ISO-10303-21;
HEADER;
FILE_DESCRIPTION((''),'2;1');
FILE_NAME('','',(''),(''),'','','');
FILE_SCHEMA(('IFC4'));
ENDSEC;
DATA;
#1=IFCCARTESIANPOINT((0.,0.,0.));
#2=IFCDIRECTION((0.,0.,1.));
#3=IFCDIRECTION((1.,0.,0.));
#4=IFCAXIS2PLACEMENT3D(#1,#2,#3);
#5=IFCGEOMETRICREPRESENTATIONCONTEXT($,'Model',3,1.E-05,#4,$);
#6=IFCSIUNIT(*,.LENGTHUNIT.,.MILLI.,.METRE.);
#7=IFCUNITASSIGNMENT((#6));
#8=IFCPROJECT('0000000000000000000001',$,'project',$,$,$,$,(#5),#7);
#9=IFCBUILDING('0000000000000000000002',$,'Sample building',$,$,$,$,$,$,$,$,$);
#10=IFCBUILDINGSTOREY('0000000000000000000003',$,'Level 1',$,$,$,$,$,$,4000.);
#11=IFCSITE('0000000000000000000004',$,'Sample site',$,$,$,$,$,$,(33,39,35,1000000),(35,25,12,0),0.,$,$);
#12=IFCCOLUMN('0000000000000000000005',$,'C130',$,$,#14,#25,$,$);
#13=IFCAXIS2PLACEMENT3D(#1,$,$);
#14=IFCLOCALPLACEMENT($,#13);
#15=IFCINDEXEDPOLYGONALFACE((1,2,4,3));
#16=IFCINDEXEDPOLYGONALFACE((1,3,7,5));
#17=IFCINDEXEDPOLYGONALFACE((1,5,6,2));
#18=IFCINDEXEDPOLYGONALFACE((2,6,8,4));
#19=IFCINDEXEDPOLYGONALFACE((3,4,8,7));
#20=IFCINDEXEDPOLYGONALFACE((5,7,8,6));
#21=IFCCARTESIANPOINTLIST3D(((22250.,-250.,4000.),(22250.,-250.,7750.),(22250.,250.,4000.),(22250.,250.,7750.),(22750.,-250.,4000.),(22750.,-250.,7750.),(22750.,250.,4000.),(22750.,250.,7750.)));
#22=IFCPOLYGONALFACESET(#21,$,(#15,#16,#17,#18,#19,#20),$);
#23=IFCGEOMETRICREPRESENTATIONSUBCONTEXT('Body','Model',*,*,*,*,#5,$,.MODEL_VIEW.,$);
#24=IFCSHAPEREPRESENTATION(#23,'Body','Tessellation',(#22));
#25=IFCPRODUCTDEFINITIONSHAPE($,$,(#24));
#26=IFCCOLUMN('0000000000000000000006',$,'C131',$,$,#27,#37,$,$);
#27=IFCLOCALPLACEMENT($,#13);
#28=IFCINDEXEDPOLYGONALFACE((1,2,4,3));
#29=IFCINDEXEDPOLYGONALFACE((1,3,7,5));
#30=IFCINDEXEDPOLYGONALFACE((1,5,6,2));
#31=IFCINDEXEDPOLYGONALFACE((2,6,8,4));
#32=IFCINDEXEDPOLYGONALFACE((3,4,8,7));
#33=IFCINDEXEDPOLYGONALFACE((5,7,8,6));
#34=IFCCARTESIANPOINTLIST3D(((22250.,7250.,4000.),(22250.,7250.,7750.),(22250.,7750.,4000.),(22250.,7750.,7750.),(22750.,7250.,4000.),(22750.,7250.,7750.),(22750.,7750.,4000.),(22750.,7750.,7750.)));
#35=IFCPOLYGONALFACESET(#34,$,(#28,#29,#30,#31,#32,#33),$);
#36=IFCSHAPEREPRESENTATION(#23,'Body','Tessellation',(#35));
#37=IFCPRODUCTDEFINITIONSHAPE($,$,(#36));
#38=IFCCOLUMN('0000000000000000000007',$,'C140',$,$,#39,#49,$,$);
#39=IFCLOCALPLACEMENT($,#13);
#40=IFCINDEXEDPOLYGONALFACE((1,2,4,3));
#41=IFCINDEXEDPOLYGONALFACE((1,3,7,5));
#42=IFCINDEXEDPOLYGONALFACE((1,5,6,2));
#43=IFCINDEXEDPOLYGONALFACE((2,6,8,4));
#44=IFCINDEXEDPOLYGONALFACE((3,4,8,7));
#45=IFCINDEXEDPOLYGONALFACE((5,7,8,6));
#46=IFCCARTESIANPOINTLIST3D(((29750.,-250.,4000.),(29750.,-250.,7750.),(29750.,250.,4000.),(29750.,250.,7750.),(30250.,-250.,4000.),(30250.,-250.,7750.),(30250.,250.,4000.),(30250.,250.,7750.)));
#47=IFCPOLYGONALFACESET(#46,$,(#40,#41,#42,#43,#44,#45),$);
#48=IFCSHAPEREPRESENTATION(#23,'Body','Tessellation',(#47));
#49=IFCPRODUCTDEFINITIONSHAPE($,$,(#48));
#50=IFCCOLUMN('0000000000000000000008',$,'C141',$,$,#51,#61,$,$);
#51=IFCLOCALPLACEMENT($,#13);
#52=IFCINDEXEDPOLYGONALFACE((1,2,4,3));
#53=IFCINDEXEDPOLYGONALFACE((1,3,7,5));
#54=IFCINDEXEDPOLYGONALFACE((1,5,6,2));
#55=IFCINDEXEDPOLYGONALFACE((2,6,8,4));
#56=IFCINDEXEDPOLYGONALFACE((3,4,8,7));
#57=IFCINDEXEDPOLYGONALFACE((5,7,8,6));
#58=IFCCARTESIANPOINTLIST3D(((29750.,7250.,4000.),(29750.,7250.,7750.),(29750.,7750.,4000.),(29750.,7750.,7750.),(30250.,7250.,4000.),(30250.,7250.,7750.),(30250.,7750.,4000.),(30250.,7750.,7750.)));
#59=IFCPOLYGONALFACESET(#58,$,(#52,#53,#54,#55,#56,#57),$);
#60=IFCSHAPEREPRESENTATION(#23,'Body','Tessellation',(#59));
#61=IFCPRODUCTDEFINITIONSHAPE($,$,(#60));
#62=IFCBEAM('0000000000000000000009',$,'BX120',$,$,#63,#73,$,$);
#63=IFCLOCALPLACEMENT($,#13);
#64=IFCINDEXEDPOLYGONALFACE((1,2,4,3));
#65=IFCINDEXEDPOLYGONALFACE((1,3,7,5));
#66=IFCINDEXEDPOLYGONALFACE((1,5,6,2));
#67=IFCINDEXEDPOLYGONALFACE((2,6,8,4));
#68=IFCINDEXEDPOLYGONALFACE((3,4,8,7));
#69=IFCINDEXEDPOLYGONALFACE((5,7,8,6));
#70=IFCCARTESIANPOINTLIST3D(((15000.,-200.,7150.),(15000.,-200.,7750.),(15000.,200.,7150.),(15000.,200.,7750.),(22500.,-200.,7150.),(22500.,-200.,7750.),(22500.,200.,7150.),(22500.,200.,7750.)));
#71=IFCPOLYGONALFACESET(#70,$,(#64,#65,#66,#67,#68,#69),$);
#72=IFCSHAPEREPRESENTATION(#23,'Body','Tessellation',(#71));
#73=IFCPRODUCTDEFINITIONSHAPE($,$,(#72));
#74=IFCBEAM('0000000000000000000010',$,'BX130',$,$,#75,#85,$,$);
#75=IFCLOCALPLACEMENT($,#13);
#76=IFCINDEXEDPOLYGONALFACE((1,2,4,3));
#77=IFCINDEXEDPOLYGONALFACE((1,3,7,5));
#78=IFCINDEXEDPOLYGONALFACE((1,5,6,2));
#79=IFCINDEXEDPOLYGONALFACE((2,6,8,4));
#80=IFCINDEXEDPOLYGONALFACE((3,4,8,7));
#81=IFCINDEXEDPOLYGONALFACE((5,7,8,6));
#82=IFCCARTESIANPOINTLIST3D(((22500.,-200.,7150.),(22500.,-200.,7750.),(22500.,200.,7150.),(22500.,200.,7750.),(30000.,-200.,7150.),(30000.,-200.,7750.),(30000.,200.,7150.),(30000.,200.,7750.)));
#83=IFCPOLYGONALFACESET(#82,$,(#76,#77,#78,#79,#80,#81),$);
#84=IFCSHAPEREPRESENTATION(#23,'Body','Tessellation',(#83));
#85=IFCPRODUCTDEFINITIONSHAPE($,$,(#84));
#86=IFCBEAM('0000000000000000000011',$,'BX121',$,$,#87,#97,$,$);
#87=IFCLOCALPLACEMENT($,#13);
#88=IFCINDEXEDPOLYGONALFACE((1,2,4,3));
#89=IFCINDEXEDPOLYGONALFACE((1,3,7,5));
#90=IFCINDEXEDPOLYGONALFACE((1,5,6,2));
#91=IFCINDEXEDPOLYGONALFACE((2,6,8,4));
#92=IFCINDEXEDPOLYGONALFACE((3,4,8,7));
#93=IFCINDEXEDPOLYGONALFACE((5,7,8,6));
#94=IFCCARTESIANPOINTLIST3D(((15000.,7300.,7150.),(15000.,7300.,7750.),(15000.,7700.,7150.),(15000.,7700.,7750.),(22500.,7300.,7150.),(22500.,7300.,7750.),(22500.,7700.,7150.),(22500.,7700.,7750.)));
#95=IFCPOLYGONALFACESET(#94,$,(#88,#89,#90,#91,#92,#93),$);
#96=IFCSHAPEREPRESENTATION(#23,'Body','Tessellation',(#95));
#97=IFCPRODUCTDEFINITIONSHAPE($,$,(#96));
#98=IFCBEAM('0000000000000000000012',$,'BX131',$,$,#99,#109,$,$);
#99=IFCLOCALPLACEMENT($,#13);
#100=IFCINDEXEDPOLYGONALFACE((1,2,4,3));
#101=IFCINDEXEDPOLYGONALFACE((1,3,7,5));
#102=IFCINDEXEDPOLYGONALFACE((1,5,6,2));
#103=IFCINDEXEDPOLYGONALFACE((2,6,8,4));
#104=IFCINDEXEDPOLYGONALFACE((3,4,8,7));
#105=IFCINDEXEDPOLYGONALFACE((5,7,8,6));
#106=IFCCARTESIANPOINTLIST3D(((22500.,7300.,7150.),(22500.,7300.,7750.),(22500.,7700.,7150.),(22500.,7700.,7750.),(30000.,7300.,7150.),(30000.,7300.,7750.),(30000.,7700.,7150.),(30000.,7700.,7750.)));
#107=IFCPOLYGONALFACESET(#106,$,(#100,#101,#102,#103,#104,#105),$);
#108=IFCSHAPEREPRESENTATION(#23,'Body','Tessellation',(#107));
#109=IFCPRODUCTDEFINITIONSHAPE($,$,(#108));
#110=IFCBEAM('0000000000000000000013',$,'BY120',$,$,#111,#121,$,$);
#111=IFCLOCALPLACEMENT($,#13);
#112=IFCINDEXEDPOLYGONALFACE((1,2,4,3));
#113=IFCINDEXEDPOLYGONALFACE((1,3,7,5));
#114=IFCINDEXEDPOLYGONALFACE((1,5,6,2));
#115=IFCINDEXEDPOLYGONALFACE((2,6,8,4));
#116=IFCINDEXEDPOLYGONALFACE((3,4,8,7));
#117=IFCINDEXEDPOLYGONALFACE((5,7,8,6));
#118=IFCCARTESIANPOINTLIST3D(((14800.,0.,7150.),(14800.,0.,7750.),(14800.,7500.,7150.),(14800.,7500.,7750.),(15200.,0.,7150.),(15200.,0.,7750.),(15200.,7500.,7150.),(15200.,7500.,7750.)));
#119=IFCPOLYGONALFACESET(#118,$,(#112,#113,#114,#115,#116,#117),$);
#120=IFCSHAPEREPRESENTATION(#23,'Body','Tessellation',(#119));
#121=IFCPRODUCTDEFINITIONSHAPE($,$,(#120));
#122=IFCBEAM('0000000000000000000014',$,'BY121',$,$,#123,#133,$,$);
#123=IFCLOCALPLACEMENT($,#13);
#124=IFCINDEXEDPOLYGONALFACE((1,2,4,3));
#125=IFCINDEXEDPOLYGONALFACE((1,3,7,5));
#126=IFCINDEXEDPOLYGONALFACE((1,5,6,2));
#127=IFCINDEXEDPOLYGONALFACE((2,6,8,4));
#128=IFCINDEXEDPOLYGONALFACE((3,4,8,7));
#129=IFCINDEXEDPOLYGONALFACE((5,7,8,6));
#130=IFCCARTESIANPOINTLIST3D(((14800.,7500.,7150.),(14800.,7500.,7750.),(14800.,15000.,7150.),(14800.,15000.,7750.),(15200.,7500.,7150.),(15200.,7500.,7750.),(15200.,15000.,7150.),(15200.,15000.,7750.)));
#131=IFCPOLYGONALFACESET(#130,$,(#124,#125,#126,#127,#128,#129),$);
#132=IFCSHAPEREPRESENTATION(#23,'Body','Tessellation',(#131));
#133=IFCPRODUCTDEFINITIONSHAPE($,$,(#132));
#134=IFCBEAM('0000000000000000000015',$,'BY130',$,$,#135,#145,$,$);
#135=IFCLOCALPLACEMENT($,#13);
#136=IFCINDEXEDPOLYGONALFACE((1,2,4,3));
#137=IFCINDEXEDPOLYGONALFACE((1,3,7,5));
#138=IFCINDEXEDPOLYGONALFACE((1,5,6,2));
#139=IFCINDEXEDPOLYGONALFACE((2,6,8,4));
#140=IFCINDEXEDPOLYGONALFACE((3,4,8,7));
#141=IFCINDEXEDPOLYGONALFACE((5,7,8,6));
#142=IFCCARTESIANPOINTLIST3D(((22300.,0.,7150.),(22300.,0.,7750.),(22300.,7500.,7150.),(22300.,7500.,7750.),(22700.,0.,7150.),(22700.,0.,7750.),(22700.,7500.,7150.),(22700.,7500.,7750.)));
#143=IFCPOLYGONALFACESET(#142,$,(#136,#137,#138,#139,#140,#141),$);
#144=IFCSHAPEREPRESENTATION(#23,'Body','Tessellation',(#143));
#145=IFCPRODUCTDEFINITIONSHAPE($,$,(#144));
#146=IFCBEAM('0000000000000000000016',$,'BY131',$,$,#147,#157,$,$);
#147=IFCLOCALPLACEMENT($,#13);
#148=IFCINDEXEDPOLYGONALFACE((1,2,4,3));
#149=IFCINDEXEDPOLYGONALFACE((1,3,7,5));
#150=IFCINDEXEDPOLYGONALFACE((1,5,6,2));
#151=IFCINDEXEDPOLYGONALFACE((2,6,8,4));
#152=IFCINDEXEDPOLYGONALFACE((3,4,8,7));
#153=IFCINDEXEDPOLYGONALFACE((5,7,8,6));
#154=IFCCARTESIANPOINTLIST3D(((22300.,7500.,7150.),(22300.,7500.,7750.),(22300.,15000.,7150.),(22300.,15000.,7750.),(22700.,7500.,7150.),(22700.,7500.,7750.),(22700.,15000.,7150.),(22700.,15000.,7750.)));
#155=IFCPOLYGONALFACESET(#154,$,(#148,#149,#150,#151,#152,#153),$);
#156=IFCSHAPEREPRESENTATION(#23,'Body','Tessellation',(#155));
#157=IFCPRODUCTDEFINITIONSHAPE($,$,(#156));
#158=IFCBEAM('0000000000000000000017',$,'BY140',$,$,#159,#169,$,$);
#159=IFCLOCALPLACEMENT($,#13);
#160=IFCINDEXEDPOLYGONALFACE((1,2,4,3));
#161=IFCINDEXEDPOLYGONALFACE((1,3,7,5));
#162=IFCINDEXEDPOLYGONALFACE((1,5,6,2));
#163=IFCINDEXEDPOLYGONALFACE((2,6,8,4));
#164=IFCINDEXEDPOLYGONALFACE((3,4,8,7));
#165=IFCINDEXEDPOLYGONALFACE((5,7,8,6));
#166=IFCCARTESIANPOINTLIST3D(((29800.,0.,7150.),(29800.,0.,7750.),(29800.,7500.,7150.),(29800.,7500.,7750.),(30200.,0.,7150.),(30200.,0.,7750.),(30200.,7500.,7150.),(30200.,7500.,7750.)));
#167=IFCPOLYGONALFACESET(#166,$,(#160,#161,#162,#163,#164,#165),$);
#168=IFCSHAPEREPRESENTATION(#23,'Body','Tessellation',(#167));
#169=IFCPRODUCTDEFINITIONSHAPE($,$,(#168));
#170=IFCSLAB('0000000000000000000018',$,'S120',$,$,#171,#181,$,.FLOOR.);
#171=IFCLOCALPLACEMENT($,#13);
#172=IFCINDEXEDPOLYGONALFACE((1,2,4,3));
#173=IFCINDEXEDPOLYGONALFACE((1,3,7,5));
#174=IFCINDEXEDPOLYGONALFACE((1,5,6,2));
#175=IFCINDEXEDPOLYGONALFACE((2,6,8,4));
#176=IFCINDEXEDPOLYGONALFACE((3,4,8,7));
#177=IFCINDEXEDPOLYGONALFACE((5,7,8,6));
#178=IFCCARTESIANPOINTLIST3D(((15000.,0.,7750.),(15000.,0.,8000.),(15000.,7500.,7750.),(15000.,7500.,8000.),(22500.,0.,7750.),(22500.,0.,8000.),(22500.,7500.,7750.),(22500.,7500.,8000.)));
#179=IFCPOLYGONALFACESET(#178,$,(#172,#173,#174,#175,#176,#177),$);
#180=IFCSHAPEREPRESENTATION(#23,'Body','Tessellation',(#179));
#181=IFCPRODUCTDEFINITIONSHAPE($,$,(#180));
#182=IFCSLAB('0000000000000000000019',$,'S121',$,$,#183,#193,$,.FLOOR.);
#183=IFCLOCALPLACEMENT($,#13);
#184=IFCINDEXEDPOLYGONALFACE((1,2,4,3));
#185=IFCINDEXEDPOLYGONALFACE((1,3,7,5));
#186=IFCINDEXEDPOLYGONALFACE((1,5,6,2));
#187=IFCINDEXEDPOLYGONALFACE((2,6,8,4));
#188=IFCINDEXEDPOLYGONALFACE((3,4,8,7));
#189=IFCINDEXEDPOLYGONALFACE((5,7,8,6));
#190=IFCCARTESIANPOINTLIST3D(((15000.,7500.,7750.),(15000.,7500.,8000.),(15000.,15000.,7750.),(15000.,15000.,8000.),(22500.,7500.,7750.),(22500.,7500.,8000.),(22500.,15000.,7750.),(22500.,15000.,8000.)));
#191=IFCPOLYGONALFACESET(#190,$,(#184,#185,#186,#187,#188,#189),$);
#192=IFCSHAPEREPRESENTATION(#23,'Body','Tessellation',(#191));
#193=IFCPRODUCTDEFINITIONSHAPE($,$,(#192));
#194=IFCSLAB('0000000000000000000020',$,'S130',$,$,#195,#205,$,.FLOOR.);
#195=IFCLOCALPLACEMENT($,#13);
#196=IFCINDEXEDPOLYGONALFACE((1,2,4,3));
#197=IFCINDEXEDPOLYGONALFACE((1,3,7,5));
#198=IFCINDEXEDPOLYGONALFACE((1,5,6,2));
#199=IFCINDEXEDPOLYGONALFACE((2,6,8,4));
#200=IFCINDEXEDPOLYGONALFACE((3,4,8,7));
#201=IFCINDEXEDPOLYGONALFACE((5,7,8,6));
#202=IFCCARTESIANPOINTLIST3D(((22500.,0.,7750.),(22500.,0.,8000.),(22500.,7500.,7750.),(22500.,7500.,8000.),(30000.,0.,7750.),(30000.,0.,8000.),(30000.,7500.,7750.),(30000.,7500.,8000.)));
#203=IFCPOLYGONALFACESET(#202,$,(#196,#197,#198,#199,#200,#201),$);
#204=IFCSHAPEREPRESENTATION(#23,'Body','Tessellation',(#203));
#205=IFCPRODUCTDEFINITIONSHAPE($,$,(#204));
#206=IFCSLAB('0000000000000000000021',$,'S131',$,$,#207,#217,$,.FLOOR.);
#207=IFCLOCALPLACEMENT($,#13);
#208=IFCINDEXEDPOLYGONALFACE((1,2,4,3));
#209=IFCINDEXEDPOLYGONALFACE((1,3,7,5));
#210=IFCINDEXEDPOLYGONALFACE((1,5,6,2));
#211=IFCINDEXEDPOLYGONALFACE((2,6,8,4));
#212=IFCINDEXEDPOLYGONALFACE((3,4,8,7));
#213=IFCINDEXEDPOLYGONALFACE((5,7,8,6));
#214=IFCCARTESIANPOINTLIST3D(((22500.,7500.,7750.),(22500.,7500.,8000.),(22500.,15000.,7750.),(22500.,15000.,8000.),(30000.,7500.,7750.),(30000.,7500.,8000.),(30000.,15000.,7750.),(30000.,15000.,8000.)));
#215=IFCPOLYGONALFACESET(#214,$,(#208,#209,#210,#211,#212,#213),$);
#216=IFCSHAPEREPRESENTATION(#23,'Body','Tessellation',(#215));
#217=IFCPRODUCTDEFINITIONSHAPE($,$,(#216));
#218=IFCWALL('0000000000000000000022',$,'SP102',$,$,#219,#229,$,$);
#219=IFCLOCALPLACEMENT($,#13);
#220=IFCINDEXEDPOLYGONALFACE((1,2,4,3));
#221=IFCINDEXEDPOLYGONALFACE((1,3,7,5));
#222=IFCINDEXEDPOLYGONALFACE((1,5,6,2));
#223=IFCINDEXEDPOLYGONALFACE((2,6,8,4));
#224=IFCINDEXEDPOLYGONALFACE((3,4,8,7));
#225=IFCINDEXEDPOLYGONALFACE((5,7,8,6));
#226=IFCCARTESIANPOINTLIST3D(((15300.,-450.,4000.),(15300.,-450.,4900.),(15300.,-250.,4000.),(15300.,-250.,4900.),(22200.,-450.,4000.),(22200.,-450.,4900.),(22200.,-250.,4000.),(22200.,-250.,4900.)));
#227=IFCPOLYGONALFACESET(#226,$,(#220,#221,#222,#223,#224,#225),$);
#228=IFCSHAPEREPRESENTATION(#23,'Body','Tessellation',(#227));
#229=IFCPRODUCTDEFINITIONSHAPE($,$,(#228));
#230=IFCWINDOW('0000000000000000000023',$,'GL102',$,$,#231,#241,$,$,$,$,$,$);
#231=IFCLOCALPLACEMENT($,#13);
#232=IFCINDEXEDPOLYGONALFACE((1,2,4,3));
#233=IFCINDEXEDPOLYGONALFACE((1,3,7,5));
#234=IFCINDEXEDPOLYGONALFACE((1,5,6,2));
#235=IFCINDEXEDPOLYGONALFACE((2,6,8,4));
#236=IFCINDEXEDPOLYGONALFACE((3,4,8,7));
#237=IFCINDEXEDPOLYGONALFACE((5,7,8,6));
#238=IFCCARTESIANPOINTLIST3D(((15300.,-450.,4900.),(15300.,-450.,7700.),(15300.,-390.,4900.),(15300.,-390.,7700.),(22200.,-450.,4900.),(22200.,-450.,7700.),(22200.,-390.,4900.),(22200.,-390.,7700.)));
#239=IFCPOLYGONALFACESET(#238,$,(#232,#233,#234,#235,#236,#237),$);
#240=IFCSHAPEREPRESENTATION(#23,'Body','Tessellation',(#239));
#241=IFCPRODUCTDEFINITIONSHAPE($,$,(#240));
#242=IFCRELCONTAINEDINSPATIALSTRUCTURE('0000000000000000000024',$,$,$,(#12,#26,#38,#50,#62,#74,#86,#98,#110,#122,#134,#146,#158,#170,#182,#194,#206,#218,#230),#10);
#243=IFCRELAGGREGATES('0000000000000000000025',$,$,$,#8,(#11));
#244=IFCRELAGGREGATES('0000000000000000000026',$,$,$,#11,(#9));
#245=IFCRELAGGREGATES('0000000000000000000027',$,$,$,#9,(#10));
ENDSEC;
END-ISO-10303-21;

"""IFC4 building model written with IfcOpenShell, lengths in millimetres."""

from ifc_helpers import new_model, si_unit, frame, origin_with_axes, place, context, subcontext, project, spatial, indexed_curve, outline, extrude, element, save


model = new_model("IFC4")

# Units and contexts
model_context = context("Model", 3, precision=1e-05, world=origin_with_axes())
body_context = subcontext(model_context, "Body", "Model", "MODEL_VIEW")
ifc_project = project(units=[si_unit("LENGTHUNIT", "METRE", prefix="MILLI")], contexts=[model_context])

# Site, building, storey
site = spatial("IfcSite", under=ifc_project, Name="Sample site", RefLatitude=(33, 39, 35, 1000000), RefLongitude=(35, 25, 12, 0), RefElevation=0.0)
building = spatial("IfcBuilding", under=site, Name="Sample building")
storey = spatial("IfcBuildingStorey", under=building, Name="Level 1", Elevation=4000.0)

# Columns
for number, where, z_axis, x_axis, name in (
    (1, (22250.0, -250.0, 4000.0), (0.0, 0.0, 1.0), (1.0, 0.0, 0.0), "C130"),
    (2, (22250.0, 7250.0, 4000.0), (0.0, 0.0, 1.0), (1.0, 0.0, 0.0), "C131"),
    (3, (29750.0, -250.0, 4000.0), (0.0, 0.0, 1.0), (1.0, 0.0, 0.0), "C140"),
    (4, (29750.0, 7250.0, 4000.0), (0.0, 0.0, 1.0), (1.0, 0.0, 0.0), "C141"),
):
    element("IfcColumn", number, at=place(None, frame(where, z_axis=z_axis, x_axis=x_axis)), inside=storey, Name=name, context=body_context, shape_type="SweptSolid", body=[
        extrude(outline(indexed_curve([(0.0, 0.0), (0.0, 500.0), (500.0, 500.0), (500.0, 0.0), (0.0, 0.0)], self_intersect=False)), origin_with_axes(), (0.0, 0.0, 1.0), 3750.0),
    ])

# Beams
for number, where, z_axis, x_axis, name in (
    (5, (15000.0, -200.0, 7150.0), (0.0, 0.0, 1.0), (1.0, 0.0, 0.0), "BX120"),
    (6, (22500.0, -200.0, 7150.0), (0.0, 0.0, 1.0), (1.0, 0.0, 0.0), "BX130"),
    (7, (15000.0, 7300.0, 7150.0), (0.0, 0.0, 1.0), (1.0, 0.0, 0.0), "BX121"),
    (8, (22500.0, 7300.0, 7150.0), (0.0, 0.0, 1.0), (1.0, 0.0, 0.0), "BX131"),
    (9, (15200.0, 0.0, 7150.0), (0.0, 0.0, 1.0), (0.0, 1.0, 0.0), "BY120"),
    (10, (15200.0, 7500.0, 7150.0), (0.0, 0.0, 1.0), (0.0, 1.0, 0.0), "BY121"),
    (11, (22700.0, 0.0, 7150.0), (0.0, 0.0, 1.0), (0.0, 1.0, 0.0), "BY130"),
    (12, (22700.0, 7500.0, 7150.0), (0.0, 0.0, 1.0), (0.0, 1.0, 0.0), "BY131"),
    (13, (30200.0, 0.0, 7150.0), (0.0, 0.0, 1.0), (0.0, 1.0, 0.0), "BY140"),
):
    element("IfcBeam", number, at=place(None, frame(where, z_axis=z_axis, x_axis=x_axis)), inside=storey, Name=name, context=body_context, shape_type="SweptSolid", body=[
        extrude(outline(indexed_curve([(0.0, 0.0), (0.0, 400.0), (7500.0, 400.0), (7500.0, 0.0), (0.0, 0.0)], self_intersect=False)), origin_with_axes(), (0.0, 0.0, 1.0), 600.0),
    ])

# Slabs
for number, where, z_axis, x_axis, name in (
    (14, (15000.0, 0.0, 7750.0), (0.0, 0.0, 1.0), (1.0, 0.0, 0.0), "S120"),
    (15, (15000.0, 7500.0, 7750.0), (0.0, 0.0, 1.0), (1.0, 0.0, 0.0), "S121"),
    (16, (22500.0, 0.0, 7750.0), (0.0, 0.0, 1.0), (1.0, 0.0, 0.0), "S130"),
    (17, (22500.0, 7500.0, 7750.0), (0.0, 0.0, 1.0), (1.0, 0.0, 0.0), "S131"),
):
    element("IfcSlab", number, at=place(None, frame(where, z_axis=z_axis, x_axis=x_axis)), inside=storey, Name=name, PredefinedType="FLOOR", context=body_context, shape_type="SweptSolid", body=[
        extrude(outline(indexed_curve([(0.0, 0.0), (0.0, 7500.0), (7500.0, 7500.0), (7500.0, 0.0), (0.0, 0.0)], self_intersect=False)), origin_with_axes(), (0.0, 0.0, 1.0), 250.0),
    ])

# Wall
wall_1_placement = place(None, frame((15300.0, -450.0, 4000.0), z_axis=(0.0, 0.0, 1.0), x_axis=(1.0, 0.0, 0.0)))
element("IfcWall", 18, at=wall_1_placement, inside=storey, Name="SP102", context=body_context, shape_type="SweptSolid", body=[
    extrude(outline(indexed_curve([(0.0, 0.0), (0.0, 200.0), (6900.0, 200.0), (6900.0, 0.0), (0.0, 0.0)], self_intersect=False)), origin_with_axes(), (0.0, 0.0, 1.0), 900.0),
])

# Window
window_1_placement = place(None, frame((15300.0, -450.0, 4900.0), z_axis=(0.0, 0.0, 1.0), x_axis=(1.0, 0.0, 0.0)))
element("IfcWindow", 19, at=window_1_placement, inside=storey, Name="GL102", context=body_context, shape_type="SweptSolid", body=[
    extrude(outline(indexed_curve([(0.0, 0.0), (0.0, 60.0), (6900.0, 60.0), (6900.0, 0.0), (0.0, 0.0)], self_intersect=False)), origin_with_axes(), (0.0, 0.0, 1.0), 2800.0),
])

save(model, "model.ifc")
